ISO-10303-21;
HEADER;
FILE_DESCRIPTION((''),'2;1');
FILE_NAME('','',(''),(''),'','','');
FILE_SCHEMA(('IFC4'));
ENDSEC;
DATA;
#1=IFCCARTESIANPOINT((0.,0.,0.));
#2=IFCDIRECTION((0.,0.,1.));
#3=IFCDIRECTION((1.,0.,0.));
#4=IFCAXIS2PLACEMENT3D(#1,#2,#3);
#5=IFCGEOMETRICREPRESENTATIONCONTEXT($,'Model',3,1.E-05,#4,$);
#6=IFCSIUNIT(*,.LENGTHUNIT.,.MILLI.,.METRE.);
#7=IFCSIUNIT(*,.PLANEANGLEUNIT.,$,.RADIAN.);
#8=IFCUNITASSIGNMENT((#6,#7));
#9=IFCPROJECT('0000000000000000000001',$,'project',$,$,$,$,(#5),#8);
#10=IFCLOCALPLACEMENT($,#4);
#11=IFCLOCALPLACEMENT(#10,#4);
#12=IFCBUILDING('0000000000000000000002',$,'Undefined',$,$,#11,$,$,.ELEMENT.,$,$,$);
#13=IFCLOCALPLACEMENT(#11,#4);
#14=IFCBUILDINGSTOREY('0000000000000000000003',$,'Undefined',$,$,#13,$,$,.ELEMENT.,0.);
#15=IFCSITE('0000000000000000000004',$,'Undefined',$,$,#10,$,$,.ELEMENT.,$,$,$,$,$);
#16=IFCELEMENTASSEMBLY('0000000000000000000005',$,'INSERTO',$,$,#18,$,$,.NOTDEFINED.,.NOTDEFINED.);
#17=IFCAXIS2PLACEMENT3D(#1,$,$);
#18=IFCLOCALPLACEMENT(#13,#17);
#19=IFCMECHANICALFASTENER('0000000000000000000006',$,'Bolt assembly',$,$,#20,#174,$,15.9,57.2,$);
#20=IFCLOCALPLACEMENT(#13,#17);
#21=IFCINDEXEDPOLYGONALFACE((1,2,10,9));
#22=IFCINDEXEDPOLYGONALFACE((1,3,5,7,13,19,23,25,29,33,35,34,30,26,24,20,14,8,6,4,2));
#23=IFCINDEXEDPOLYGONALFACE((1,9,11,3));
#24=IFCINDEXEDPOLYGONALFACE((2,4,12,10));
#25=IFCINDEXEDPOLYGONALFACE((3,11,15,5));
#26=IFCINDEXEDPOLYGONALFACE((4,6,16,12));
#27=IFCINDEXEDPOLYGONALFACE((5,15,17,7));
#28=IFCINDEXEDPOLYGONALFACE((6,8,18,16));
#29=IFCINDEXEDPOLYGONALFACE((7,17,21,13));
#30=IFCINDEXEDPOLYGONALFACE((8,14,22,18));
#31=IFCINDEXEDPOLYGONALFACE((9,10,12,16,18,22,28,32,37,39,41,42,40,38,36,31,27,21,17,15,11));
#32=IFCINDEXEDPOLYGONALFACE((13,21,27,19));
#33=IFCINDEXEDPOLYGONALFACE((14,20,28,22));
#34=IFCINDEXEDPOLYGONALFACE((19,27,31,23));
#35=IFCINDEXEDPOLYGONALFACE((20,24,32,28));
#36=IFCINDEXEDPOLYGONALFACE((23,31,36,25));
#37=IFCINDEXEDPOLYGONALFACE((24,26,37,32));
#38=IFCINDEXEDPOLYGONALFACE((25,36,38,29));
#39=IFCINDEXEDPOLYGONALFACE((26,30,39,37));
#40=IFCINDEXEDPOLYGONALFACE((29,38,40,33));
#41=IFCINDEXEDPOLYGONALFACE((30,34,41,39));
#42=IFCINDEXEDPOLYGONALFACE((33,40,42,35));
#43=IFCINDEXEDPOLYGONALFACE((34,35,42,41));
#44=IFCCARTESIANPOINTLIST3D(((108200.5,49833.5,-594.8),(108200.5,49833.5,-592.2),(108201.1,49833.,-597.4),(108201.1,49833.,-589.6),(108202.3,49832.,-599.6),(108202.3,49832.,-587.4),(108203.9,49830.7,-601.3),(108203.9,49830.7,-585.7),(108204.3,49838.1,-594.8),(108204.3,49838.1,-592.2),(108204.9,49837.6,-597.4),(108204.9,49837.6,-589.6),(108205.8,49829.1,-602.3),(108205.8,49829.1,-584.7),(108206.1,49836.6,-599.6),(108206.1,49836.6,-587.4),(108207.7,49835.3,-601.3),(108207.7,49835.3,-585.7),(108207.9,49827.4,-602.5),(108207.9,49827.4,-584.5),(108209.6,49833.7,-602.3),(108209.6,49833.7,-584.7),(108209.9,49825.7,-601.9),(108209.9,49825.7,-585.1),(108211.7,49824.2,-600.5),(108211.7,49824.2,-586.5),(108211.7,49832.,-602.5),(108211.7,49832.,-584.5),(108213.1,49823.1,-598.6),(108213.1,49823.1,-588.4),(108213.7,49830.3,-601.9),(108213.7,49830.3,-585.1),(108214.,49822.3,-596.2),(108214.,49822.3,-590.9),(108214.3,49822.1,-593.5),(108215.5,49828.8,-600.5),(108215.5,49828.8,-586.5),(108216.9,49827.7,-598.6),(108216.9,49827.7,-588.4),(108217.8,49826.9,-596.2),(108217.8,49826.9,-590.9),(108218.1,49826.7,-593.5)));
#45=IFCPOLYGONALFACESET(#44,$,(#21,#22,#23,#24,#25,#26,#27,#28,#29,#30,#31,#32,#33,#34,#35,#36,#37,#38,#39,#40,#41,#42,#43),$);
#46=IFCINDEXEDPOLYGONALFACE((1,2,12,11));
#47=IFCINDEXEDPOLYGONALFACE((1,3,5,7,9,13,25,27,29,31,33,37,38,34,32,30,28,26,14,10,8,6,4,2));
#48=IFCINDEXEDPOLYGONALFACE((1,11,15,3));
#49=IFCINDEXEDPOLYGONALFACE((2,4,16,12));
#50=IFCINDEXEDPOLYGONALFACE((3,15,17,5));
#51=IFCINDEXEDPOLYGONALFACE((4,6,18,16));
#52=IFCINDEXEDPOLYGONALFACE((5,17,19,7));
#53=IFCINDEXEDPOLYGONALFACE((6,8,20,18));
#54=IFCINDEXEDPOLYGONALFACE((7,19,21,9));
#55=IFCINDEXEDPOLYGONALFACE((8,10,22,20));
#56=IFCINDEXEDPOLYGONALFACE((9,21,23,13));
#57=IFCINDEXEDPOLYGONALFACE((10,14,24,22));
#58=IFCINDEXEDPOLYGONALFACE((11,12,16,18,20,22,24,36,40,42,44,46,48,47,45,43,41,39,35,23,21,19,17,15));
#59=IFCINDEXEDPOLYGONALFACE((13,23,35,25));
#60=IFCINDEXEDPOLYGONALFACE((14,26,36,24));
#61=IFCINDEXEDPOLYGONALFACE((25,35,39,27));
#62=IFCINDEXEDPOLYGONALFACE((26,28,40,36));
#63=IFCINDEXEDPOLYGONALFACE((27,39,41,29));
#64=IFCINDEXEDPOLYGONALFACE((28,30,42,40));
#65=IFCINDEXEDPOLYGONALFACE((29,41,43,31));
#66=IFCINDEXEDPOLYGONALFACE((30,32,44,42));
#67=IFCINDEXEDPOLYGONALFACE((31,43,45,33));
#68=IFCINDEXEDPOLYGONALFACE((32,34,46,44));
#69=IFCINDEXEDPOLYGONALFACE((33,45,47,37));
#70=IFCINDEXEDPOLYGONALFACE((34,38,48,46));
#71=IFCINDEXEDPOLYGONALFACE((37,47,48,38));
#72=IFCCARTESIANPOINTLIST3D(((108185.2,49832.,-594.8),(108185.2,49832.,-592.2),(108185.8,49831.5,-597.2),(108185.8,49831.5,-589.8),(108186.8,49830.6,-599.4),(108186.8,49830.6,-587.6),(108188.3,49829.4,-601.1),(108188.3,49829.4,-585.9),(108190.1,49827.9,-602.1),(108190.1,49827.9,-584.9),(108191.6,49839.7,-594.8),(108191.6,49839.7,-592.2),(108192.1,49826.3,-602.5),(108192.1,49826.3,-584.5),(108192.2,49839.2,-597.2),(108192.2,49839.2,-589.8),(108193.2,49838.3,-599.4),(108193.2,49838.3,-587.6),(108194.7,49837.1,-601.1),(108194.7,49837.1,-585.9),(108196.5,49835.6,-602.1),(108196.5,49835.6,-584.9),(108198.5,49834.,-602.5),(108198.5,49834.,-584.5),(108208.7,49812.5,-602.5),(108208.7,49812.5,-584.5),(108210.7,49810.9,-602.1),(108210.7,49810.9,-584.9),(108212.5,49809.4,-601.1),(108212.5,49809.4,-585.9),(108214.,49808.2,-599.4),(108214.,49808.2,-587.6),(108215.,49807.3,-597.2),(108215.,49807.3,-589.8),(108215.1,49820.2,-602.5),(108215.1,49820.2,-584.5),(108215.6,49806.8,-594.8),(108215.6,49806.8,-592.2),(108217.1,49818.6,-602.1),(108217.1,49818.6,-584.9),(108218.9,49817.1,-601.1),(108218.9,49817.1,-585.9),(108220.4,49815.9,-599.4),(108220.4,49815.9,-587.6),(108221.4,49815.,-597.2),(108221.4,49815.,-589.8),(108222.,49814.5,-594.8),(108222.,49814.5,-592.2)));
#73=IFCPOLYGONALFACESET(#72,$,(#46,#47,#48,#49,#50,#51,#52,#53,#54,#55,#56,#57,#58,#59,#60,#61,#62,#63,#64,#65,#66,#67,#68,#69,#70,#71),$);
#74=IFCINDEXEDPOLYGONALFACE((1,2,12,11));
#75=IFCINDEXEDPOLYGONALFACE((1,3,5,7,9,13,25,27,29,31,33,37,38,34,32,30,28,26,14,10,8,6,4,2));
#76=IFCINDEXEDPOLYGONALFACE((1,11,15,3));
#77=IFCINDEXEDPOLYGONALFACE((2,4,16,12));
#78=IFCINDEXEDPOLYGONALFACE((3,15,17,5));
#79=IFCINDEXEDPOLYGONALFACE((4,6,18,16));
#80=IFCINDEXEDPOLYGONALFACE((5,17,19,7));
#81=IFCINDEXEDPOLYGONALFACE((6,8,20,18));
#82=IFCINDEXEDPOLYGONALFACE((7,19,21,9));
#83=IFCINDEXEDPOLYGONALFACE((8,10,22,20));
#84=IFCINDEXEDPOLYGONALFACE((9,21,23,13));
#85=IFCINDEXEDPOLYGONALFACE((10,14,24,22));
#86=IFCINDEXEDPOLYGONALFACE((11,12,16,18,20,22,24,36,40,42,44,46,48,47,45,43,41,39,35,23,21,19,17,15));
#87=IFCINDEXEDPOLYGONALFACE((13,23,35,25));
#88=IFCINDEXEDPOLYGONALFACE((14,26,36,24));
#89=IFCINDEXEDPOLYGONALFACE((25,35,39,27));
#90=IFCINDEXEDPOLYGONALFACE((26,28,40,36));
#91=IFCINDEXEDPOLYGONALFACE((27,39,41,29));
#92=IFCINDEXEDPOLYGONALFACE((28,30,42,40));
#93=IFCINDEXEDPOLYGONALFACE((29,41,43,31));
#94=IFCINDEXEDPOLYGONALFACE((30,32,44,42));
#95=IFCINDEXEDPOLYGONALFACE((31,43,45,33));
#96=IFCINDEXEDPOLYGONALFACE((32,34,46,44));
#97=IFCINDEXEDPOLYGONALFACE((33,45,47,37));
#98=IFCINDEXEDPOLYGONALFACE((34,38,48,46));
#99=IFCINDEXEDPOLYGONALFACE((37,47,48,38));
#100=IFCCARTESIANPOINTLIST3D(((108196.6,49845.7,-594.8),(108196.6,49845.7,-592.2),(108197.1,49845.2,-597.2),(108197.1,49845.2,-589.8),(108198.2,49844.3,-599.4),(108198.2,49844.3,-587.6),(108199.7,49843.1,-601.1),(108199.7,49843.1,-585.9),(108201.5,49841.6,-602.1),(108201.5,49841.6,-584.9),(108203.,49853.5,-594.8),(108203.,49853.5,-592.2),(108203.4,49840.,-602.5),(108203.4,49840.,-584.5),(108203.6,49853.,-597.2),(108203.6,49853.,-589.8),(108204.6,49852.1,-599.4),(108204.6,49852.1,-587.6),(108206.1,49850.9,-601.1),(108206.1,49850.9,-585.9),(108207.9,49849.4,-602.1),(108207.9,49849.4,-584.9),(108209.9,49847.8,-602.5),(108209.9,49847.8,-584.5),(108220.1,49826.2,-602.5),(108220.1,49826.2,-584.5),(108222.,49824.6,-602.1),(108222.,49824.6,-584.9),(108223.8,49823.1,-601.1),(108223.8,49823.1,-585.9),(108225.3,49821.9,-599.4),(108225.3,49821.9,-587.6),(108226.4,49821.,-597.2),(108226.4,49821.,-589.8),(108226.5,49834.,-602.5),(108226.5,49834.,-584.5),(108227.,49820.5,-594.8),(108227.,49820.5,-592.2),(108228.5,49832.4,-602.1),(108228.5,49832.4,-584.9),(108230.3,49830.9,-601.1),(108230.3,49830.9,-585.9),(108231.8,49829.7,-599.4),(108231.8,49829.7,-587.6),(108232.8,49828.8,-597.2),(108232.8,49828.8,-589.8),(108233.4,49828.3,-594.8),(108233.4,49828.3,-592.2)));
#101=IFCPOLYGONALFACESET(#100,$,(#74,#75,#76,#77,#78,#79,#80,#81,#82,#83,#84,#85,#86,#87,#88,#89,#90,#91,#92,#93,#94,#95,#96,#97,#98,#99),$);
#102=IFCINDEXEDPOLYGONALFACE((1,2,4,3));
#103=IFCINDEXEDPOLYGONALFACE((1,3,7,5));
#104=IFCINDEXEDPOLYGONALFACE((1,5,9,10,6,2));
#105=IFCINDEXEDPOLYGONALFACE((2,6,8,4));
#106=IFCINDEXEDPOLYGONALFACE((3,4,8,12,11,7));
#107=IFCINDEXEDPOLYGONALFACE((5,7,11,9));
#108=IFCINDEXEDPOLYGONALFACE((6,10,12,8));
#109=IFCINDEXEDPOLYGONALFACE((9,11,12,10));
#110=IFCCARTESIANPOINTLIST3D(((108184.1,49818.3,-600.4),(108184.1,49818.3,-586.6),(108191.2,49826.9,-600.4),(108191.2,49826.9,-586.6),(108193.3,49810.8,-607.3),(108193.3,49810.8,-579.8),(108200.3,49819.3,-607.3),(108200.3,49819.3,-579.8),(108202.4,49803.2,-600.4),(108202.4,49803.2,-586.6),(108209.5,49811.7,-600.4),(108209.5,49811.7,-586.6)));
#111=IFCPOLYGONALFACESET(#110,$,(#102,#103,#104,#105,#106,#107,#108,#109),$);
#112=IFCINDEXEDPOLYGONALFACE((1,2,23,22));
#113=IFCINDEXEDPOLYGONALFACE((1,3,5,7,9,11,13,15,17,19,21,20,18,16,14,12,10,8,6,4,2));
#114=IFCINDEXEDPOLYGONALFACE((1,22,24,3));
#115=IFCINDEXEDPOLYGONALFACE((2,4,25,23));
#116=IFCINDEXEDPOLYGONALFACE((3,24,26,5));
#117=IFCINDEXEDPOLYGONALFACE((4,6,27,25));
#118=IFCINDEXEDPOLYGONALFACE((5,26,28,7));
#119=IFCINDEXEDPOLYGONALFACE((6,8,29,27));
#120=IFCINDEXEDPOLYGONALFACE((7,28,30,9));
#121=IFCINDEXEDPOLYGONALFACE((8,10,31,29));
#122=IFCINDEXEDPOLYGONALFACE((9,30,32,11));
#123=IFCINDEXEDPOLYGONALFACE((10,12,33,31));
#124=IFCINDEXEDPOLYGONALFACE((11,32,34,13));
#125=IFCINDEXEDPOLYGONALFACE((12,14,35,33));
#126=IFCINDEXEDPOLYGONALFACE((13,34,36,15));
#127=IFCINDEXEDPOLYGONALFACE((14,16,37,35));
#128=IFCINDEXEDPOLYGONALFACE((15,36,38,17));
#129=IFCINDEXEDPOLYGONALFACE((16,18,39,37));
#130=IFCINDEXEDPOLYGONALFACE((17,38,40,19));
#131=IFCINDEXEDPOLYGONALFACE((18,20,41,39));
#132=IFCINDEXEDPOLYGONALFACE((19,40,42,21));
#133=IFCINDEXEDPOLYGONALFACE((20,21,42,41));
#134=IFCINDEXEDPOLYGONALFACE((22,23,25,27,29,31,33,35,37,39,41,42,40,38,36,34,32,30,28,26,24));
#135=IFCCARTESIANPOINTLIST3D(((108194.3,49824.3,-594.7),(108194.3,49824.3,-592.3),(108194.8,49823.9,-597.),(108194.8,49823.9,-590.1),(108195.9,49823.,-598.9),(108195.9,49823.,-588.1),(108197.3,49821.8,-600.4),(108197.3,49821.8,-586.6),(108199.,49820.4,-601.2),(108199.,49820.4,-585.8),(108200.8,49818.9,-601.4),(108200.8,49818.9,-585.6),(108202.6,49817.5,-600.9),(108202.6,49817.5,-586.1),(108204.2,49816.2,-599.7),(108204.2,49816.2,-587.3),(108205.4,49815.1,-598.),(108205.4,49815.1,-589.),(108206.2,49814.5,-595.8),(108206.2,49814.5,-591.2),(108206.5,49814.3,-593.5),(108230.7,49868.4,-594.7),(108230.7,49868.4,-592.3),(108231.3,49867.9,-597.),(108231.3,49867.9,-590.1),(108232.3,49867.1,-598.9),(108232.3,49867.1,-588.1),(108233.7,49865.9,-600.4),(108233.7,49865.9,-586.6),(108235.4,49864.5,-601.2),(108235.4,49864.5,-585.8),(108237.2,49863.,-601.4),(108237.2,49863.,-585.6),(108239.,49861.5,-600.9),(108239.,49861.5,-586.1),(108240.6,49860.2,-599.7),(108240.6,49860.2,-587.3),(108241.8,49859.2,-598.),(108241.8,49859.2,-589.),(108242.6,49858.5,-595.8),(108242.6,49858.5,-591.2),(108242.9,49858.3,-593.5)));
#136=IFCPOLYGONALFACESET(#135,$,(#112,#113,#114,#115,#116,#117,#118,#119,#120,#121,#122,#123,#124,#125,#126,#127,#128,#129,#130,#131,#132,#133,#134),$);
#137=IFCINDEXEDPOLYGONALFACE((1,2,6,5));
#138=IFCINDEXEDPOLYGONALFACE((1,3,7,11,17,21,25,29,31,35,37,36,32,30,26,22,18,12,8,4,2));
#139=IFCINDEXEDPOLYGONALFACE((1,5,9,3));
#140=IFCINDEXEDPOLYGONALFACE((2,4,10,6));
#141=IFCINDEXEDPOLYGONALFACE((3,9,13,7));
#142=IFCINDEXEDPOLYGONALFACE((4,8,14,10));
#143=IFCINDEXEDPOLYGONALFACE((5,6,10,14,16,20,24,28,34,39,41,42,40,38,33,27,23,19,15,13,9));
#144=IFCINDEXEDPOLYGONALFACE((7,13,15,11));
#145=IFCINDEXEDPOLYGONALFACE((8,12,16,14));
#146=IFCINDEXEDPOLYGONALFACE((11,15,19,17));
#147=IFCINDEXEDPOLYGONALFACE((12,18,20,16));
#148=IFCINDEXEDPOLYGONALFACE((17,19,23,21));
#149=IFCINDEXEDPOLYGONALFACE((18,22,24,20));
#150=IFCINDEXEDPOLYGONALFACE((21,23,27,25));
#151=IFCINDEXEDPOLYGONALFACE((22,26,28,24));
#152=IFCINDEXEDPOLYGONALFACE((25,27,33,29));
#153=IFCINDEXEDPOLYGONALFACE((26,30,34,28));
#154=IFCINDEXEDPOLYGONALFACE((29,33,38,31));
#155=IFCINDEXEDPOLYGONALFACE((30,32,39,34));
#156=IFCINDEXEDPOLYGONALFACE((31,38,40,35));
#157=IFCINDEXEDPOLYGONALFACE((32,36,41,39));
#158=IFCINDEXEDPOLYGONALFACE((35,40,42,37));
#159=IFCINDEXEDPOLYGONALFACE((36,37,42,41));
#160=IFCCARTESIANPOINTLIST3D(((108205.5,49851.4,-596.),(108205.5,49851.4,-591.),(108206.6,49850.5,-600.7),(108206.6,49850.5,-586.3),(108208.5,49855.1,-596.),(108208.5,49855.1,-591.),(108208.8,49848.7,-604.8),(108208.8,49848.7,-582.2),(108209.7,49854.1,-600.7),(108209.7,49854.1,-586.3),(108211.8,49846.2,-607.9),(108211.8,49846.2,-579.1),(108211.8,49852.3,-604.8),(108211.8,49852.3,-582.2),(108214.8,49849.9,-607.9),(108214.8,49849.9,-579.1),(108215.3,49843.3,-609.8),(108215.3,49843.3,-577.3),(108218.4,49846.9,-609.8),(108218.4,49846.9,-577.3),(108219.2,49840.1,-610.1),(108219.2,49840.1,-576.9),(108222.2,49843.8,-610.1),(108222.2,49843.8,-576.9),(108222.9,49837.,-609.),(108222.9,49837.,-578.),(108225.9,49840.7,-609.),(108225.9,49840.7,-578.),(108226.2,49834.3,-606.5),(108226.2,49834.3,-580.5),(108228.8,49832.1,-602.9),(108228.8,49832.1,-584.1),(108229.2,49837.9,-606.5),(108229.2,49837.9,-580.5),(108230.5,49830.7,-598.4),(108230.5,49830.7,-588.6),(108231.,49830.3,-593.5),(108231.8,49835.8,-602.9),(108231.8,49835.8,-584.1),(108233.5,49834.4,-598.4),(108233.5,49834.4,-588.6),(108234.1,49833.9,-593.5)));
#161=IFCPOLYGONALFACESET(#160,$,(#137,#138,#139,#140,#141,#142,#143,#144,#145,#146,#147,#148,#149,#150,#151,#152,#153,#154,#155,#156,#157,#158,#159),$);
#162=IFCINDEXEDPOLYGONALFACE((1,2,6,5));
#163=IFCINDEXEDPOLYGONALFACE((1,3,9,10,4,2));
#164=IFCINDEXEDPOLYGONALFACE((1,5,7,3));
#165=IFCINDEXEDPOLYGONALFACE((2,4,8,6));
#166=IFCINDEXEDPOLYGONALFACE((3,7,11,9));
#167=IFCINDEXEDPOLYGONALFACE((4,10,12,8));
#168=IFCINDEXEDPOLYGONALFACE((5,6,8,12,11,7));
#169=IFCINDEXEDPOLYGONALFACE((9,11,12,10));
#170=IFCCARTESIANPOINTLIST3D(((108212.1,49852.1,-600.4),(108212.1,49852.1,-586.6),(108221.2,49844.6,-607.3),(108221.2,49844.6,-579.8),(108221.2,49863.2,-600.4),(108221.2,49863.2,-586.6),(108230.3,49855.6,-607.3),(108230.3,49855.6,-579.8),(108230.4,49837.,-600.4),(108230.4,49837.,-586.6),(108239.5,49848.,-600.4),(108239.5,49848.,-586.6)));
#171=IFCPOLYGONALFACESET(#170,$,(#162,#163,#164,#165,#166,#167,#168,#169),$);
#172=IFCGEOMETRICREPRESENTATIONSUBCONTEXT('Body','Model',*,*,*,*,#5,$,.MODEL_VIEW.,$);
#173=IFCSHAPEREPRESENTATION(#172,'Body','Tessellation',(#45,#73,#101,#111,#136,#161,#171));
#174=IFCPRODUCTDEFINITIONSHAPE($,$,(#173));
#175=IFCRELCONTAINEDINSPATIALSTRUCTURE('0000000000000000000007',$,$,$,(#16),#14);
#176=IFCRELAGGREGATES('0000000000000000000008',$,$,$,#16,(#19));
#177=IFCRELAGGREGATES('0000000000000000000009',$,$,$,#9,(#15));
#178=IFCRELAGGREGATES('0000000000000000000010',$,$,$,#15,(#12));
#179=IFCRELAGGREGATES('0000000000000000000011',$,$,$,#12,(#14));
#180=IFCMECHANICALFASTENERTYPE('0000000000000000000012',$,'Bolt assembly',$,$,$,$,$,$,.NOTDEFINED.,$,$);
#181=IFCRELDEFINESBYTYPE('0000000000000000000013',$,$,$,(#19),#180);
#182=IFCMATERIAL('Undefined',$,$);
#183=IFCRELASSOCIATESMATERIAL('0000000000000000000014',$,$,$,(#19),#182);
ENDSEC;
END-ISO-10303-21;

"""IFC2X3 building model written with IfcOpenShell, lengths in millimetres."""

from ifc_helpers import new_model, entity, si_unit, frame, origin_with_axes, origin_2d_with_axis, place, context, subcontext, project, spatial, polyline, circle, outline, extrude, source, transform, mapped, material, type_object, element, aggregate, save


model = new_model("IFC2X3")

# Units and contexts
model_context = context("Model", 3, precision=1e-05, world=origin_with_axes())
body_context = subcontext(model_context, "Body", "Model", "MODEL_VIEW")
ifc_project = project(units=[si_unit("LENGTHUNIT", "METRE", prefix="MILLI"), si_unit("PLANEANGLEUNIT", "RADIAN")], contexts=[model_context])

# Site, building, storey
site_placement = place(None, origin_with_axes())
site = spatial("IfcSite", under=ifc_project, at=site_placement, Name="Undefined", CompositionType="ELEMENT")
building_placement = place(site_placement, origin_with_axes())
building = spatial("IfcBuilding", under=site, at=building_placement, Name="Undefined", CompositionType="ELEMENT")
storey_placement = place(building_placement, origin_with_axes())
storey = spatial("IfcBuildingStorey", under=building, at=storey_placement, Name="Undefined", CompositionType="ELEMENT", Elevation=0.0)

# Element assembly
assembly_1_placement = place(storey_placement, origin_with_axes())
assembly_1 = element("IfcElementAssembly", 1, at=assembly_1_placement, inside=storey, Name="INSERTO", AssemblyPlace="NOTDEFINED", PredefinedType="NOTDEFINED")

# Mechanical fastener
ifc_material_1 = material(Name="Undefined")
mechanical_fastener_type = type_object("IfcMechanicalFastenerType", Name="Bolt assembly")
shared_circle_1 = entity("IfcCircle", entity("IfcAxis2Placement2D", entity("IfcCartesianPoint", [10.8, 0.0]), entity("IfcDirection", [0.0, 1.0])), 9.0)
shared_circle_2 = entity("IfcCircle", entity("IfcAxis2Placement2D", entity("IfcCartesianPoint", [-10.8, 0.0]), entity("IfcDirection", [0.0, -1.0])), 9.0)
shared_composite_curve = entity("IfcCompositeCurve", [entity("IfcCompositeCurveSegment", "CONTINUOUS", True, entity("IfcPolyline", [entity("IfcCartesianPoint", [-10.8, 9.0]), entity("IfcCartesianPoint", [10.8, 9.0])])), entity("IfcCompositeCurveSegment", "CONTINUOUS", True, entity("IfcTrimmedCurve", shared_circle_1, [entity("IfcParameterValue", 0.0)], [entity("IfcParameterValue", 3.141593)], False, "PARAMETER")), entity("IfcCompositeCurveSegment", "CONTINUOUS", True, entity("IfcPolyline", [entity("IfcCartesianPoint", [10.8, -9.0]), entity("IfcCartesianPoint", [-10.8, -9.0])])), entity("IfcCompositeCurveSegment", "DISCONTINUOUS", True, entity("IfcTrimmedCurve", shared_circle_2, [entity("IfcParameterValue", 0.0)], [entity("IfcParameterValue", 3.141593)], False, "PARAMETER"))], False)
shared_shape_1 = source(origin_with_axes(), body_context, "Body", "SweptSolid", [
    extrude(circle(Radius=9.0, at=origin_2d_with_axis()), frame((0.0, 6.0, 0.0), z_axis=(0.0, 1.0, 0.0), x_axis=(1.0, 0.0, 0.0)), (0.0, 0.0, 1.0), 6.0),
    entity("IfcExtrudedAreaSolid", entity("IfcArbitraryClosedProfileDef", "AREA", None, shared_composite_curve), entity("IfcAxis2Placement3D", entity("IfcCartesianPoint", [0.0, -4.9, 0.0]), entity("IfcDirection", [0.0, 1.0, 0.0]), entity("IfcDirection", [1.0, 0.0, 0.0])), entity("IfcDirection", [0.0, 0.0, 1.0]), 10.0),
    entity("IfcExtrudedAreaSolid", entity("IfcArbitraryClosedProfileDef", "AREA", None, shared_composite_curve), entity("IfcAxis2Placement3D", entity("IfcCartesianPoint", [0.0, 12.9, 0.0]), entity("IfcDirection", [0.0, 1.0, 0.0]), entity("IfcDirection", [1.0, 0.0, 0.0])), entity("IfcDirection", [0.0, 0.0, 1.0]), 10.1),
    extrude(outline(polyline([(11.9, -6.9), (11.9, 6.9), (0.0, 13.7), (-11.9, 6.9), (-11.9, -6.9), (0.0, -13.7), (11.9, -6.9)])), frame((0.0, -16.1, 0.0), z_axis=(0.0, 1.0, 0.0), x_axis=(1.0, 0.0, 0.0)), (0.0, 0.0, 1.0), 11.1),
    extrude(circle(Radius=7.9, at=origin_2d_with_axis()), frame((0.0, -5.0, 0.0), z_axis=(0.0, 1.0, 0.0), x_axis=(1.0, 0.0, 0.0)), (0.0, 0.0, 1.0), 57.1),
    extrude(circle(Radius=16.7, at=origin_2d_with_axis()), frame((0.0, 23.0, 0.0), z_axis=(0.0, 1.0, 0.0), x_axis=(1.0, 0.0, 0.0)), (0.0, 0.0, 1.0), 4.8),
    extrude(outline(polyline([(11.9, -6.9), (11.9, 6.9), (0.0, 13.7), (-11.9, 6.9), (-11.9, -6.9), (0.0, -13.7), (11.9, -6.9)])), frame((0.0, 27.8, 0.0), z_axis=(0.0, 1.0, 0.0), x_axis=(1.0, 0.0, 0.0)), (0.0, 0.0, 1.0), 14.3),
])
mechanical_fastener_1_placement = place(assembly_1_placement, frame((108203.5, 49823.2, -593.5), z_axis=(0.0, 0.0, 1.0), x_axis=(0.7704, -0.63756, 0.0)))
mechanical_fastener_1 = element("IfcMechanicalFastener", 2, at=mechanical_fastener_1_placement, type_object=mechanical_fastener_type, material=ifc_material_1, Name="Bolt assembly", NominalDiameter=15.9, NominalLength=57.2, context=body_context, shape_type="MappedRepresentation", body=[
    mapped(shared_shape_1, transform((0.0, 0.0, 0.0))),
])
aggregate(assembly_1, [mechanical_fastener_1])

save(model, "model.ifc")
